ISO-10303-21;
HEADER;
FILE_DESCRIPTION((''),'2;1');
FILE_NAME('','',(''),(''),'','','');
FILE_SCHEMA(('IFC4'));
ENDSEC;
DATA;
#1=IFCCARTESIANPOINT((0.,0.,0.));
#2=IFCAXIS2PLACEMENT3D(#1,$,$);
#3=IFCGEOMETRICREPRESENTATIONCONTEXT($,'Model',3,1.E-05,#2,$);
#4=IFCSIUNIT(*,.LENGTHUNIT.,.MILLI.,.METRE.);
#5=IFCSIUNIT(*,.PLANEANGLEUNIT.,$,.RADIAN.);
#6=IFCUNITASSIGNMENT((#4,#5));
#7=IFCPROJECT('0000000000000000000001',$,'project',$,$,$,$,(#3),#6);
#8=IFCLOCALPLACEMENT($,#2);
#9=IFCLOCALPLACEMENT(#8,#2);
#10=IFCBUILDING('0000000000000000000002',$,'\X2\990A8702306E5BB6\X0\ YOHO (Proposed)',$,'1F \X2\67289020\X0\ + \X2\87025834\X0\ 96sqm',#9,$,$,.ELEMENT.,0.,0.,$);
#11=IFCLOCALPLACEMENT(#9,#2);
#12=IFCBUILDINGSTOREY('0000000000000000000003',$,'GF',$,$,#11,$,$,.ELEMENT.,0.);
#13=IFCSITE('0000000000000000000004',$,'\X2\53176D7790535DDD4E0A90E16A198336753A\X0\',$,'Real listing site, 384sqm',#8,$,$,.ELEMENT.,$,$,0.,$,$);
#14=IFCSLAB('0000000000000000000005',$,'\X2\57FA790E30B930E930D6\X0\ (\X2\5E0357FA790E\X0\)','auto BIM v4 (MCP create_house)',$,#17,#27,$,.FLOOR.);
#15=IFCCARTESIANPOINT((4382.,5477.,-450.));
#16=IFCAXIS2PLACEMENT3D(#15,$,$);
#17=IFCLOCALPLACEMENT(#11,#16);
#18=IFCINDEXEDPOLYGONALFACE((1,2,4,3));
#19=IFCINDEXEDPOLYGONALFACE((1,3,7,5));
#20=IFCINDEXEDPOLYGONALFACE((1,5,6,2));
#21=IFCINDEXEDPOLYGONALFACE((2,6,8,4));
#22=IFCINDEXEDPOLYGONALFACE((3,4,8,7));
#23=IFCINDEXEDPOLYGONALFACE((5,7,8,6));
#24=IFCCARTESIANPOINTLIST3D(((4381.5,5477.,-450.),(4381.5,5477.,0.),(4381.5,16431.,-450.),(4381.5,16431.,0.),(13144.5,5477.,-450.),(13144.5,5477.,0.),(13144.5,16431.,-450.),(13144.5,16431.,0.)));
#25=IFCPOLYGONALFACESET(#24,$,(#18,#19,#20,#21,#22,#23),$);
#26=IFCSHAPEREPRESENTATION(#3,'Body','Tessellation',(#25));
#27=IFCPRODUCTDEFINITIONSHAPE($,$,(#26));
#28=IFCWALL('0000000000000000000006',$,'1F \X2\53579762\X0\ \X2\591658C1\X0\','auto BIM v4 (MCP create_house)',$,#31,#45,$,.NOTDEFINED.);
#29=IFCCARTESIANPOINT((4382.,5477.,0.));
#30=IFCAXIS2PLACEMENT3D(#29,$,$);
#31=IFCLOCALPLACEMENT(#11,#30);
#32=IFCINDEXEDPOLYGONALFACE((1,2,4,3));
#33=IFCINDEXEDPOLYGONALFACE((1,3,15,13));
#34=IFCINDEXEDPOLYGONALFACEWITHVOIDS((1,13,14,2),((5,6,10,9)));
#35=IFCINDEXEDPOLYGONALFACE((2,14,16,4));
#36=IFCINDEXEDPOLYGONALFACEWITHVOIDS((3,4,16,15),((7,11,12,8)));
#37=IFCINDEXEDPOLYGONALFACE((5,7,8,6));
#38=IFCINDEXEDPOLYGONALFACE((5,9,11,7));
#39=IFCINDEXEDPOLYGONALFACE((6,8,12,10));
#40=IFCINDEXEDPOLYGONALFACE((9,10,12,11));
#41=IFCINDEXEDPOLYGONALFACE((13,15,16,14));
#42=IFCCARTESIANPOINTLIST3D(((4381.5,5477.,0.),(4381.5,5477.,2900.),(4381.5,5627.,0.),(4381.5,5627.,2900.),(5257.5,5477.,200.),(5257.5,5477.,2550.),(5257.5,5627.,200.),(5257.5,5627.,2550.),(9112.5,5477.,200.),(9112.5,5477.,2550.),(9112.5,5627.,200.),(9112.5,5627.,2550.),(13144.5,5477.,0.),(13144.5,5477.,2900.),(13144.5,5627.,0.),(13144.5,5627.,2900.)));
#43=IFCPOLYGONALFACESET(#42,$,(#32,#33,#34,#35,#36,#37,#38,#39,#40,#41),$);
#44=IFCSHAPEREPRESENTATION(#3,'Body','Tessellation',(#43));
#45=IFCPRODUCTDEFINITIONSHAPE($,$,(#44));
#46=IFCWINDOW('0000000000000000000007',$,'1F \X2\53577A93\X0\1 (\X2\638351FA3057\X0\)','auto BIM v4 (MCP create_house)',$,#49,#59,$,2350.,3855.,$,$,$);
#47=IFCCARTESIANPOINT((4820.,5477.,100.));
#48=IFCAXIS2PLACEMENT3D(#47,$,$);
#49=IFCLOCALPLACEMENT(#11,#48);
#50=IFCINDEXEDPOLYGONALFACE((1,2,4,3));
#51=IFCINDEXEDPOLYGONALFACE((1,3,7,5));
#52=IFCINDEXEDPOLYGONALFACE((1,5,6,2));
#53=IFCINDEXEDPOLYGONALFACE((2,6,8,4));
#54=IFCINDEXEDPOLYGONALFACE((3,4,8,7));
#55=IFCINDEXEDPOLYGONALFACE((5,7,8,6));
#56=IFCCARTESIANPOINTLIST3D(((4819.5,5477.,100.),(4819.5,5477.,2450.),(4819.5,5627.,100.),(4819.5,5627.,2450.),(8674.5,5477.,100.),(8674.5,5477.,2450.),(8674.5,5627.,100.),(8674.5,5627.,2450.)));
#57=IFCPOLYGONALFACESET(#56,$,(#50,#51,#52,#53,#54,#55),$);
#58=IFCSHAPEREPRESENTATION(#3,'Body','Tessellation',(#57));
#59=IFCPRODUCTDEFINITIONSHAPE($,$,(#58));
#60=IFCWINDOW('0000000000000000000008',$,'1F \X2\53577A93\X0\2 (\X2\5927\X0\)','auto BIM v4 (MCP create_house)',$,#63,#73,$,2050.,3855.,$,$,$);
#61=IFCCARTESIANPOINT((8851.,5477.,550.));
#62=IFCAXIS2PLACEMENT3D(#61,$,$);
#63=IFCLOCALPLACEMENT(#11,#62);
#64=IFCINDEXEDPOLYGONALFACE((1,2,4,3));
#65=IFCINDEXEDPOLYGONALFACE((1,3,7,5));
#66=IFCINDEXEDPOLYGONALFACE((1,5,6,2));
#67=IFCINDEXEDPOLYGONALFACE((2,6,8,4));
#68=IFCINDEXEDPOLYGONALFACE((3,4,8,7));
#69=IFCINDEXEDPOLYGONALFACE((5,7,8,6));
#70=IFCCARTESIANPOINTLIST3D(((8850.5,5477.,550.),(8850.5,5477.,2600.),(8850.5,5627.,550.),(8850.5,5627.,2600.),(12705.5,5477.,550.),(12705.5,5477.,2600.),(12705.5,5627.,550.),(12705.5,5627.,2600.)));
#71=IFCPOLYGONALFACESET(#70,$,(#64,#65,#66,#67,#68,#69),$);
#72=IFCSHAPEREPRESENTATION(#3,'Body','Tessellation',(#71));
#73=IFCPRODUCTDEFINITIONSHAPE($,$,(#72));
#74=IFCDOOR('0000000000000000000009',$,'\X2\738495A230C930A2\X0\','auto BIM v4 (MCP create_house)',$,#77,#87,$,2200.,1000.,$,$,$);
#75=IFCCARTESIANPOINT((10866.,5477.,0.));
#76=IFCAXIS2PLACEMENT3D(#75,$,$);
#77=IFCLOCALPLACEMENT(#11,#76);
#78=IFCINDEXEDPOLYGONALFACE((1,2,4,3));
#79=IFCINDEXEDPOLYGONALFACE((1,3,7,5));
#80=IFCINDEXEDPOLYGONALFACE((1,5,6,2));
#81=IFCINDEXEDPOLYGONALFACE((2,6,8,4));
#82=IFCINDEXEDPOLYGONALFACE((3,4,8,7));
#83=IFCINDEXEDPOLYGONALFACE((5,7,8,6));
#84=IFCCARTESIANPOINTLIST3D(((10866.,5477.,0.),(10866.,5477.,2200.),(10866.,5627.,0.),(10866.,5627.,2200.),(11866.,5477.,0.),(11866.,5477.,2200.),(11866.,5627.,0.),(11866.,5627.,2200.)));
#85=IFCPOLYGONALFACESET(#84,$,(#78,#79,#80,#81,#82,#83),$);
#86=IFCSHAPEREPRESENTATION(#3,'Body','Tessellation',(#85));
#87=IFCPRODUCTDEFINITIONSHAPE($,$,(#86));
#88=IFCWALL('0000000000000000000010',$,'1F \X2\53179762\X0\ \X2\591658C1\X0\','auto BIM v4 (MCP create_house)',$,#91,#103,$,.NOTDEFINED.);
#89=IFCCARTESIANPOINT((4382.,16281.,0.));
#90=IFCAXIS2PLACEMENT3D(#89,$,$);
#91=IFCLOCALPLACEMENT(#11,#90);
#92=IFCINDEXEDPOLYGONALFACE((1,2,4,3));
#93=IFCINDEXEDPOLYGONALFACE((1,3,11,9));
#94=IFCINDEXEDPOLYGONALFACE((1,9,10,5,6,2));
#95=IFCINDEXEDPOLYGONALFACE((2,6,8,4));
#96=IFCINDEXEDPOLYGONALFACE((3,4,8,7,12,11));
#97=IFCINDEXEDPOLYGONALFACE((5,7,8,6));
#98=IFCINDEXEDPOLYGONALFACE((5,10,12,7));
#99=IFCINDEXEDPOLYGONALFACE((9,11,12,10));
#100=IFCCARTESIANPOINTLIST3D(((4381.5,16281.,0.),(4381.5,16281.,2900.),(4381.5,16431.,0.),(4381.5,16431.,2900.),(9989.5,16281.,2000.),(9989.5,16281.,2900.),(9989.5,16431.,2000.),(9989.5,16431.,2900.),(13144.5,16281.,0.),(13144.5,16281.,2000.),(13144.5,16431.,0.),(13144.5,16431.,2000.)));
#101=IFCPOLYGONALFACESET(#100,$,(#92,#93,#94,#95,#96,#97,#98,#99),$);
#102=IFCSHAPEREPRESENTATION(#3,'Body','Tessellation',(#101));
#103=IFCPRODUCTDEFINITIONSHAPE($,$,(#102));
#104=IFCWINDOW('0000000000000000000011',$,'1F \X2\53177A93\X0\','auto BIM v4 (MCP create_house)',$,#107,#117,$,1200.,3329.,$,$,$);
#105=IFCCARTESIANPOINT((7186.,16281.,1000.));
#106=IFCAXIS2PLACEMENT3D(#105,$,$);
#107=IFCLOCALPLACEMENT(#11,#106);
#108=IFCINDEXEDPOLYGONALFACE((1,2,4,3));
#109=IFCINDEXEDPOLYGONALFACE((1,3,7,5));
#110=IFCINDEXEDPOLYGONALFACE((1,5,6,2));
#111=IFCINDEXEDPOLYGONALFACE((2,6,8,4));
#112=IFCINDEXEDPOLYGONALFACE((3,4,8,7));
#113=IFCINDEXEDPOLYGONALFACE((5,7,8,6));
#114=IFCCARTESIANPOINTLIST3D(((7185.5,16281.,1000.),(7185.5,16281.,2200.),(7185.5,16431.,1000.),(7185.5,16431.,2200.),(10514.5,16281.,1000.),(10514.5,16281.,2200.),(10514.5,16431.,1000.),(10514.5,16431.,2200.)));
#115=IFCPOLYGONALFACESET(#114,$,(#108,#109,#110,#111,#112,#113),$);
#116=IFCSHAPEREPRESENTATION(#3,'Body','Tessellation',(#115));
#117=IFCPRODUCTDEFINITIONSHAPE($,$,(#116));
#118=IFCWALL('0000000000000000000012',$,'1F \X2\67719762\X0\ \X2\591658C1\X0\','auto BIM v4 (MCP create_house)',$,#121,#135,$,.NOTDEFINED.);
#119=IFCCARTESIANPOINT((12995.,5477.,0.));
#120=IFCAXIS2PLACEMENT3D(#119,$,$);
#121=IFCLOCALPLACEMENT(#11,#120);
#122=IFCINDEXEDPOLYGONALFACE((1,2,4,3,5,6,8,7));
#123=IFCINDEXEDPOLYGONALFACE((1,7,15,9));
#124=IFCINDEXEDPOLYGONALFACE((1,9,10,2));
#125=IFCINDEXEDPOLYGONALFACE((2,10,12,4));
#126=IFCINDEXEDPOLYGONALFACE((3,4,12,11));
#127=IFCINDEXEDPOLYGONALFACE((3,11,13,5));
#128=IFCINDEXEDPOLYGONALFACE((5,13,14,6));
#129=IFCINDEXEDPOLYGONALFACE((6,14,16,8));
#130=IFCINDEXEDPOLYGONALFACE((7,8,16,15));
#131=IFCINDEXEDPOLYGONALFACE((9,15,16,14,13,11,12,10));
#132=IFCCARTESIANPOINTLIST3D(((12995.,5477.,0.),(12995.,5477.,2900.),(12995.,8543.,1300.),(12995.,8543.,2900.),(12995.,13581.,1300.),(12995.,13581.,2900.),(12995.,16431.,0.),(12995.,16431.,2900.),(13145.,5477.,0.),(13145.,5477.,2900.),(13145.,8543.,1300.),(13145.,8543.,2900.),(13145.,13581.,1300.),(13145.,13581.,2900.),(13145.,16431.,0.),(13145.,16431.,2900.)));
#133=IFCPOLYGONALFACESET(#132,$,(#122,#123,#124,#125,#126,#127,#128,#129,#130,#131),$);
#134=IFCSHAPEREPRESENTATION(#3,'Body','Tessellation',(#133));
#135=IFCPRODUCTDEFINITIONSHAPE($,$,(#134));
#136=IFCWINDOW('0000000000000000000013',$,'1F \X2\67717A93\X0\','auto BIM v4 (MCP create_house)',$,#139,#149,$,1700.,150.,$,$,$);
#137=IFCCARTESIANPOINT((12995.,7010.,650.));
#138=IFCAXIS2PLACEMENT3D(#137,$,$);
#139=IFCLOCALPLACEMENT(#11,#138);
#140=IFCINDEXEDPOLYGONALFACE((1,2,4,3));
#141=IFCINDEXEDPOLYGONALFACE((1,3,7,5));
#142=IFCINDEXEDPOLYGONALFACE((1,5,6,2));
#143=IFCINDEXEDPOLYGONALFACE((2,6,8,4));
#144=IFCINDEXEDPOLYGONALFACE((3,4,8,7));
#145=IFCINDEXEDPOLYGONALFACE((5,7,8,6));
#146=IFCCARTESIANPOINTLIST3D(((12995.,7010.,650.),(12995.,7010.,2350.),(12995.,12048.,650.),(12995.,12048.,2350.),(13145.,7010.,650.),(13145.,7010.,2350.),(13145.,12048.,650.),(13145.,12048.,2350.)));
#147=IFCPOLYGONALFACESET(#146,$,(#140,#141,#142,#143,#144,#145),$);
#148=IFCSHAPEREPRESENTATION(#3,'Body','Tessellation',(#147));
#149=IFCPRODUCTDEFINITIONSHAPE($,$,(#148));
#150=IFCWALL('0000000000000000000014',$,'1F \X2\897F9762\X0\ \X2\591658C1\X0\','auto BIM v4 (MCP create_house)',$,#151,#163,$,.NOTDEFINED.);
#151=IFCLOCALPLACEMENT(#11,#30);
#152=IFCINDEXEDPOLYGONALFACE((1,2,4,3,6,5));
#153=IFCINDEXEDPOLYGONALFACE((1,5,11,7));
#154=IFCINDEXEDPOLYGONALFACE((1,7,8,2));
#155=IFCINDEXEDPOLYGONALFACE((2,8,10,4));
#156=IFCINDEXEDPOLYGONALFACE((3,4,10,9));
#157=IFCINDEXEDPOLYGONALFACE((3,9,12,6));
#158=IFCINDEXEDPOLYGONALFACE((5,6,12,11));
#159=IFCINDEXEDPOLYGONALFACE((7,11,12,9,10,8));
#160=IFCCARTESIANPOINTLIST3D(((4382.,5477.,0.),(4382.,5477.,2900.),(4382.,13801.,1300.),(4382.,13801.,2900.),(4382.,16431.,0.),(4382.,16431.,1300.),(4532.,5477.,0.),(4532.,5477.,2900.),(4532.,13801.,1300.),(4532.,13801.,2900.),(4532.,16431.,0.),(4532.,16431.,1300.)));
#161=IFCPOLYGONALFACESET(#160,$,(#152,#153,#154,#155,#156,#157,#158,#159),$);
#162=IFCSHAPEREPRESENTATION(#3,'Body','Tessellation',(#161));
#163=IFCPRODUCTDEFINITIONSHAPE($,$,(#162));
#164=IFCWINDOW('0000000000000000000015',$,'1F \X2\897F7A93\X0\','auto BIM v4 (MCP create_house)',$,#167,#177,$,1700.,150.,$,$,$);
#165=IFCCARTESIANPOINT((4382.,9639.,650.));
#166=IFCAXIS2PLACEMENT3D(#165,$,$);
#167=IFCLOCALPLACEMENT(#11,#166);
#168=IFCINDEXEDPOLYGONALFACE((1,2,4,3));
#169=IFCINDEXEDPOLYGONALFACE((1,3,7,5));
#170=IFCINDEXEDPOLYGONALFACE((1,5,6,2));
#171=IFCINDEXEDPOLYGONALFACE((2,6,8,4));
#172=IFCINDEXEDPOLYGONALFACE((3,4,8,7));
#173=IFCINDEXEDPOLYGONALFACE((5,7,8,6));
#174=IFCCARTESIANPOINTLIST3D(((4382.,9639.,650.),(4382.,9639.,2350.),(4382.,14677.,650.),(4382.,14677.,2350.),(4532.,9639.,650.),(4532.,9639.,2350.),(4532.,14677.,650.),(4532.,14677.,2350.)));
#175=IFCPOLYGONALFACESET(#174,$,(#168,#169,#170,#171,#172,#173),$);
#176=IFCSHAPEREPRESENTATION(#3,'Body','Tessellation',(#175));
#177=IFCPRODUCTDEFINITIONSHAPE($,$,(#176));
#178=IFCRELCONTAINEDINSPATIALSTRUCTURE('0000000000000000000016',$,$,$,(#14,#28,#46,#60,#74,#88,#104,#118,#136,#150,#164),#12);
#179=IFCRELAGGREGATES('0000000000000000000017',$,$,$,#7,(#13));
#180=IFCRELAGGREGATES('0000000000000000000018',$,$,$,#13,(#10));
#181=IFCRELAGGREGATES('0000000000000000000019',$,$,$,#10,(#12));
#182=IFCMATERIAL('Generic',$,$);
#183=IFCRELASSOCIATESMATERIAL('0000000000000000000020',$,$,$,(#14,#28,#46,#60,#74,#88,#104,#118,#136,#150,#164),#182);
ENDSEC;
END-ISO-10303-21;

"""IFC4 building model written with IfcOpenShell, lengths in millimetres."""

from ifc_helpers import new_model, si_unit, frame, frame_2d, origin, place, context, project, spatial, rectangle, extrude, material, element, fill, save


model = new_model("IFC4")

# Units and contexts
model_context = context("Model", 3, precision=1e-05, world=origin())
ifc_project = project(units=[si_unit("LENGTHUNIT", "METRE", prefix="MILLI"), si_unit("PLANEANGLEUNIT", "RADIAN")], contexts=[model_context])

# Site, building, storey
site_placement = place(None, origin())
site = spatial("IfcSite", under=ifc_project, at=site_placement, Name="北海道川上郡標茶町", ObjectType="Real listing site, 384sqm", CompositionType="ELEMENT", RefElevation=0.0)
building_placement = place(site_placement, origin())
building = spatial("IfcBuilding", under=site, at=building_placement, Name="養蜂の家 YOHO (Proposed)", ObjectType="1F 木造 + 蜂場 96sqm", CompositionType="ELEMENT", ElevationOfRefHeight=0.0, ElevationOfTerrain=0.0)
storey_placement = place(building_placement, origin())
storey = spatial("IfcBuildingStorey", under=building, at=storey_placement, Name="GF", CompositionType="ELEMENT", Elevation=0.0)

# Slab
ifc_material = material(Name="Generic")
slab_1_placement = place(storey_placement, frame((4382.0, 5477.0, -450.0)))
element("IfcSlab", 1, at=slab_1_placement, inside=storey, material=ifc_material, Name="基礎スラブ (布基礎)", Description="auto BIM v4 (MCP create_house)", PredefinedType="FLOOR", context=model_context, shape_type="SweptSolid", body=[
    extrude(rectangle(XDim=8763.0, YDim=10954.0, at=frame_2d((4381.0, 5477.0))), frame((4382.0, 5477.0, -450.0)), (0.0, 0.0, 1.0), 450.0),
])

# Wall, openings, windows, door
wall_1_placement = place(storey_placement, frame((4382.0, 5477.0, 0.0)))
wall_1 = element("IfcWall", 2, at=wall_1_placement, inside=storey, material=ifc_material, Name="1F 南面 外壁", Description="auto BIM v4 (MCP create_house)", PredefinedType="NOTDEFINED", context=model_context, shape_type="SweptSolid", body=[
    extrude(rectangle(XDim=8763.0, YDim=150.0, at=frame_2d((4381.0, 75.0))), frame((4382.0, 5477.0, 0.0)), (0.0, 0.0, 1.0), 2900.0),
])
opening_1_placement = place(storey_placement, frame((4820.0, 5477.0, 100.0)))
opening_1 = element("IfcOpeningElement", 3, at=opening_1_placement, cuts=wall_1, PredefinedType="NOTDEFINED", context=model_context, shape_type="SweptSolid", body=[
    extrude(rectangle(XDim=3855.0, YDim=150.0, at=frame_2d((1927.0, 75.0))), frame((4820.0, 5477.0, 100.0)), (0.0, 0.0, 1.0), 2350.0),
])
opening_2_placement = place(storey_placement, frame((8851.0, 5477.0, 550.0)))
opening_2 = element("IfcOpeningElement", 4, at=opening_2_placement, cuts=wall_1, PredefinedType="NOTDEFINED", context=model_context, shape_type="SweptSolid", body=[
    extrude(rectangle(XDim=3855.0, YDim=150.0, at=frame_2d((1927.0, 75.0))), frame((8851.0, 5477.0, 550.0)), (0.0, 0.0, 1.0), 2050.0),
])
opening_3_placement = place(storey_placement, frame((10866.0, 5477.0, 0.0)))
opening_3 = element("IfcOpeningElement", 5, at=opening_3_placement, cuts=wall_1, PredefinedType="NOTDEFINED", context=model_context, shape_type="SweptSolid", body=[
    extrude(rectangle(XDim=1000.0, YDim=150.0, at=frame_2d((500.0, 75.0))), frame((10866.0, 5477.0, 0.0)), (0.0, 0.0, 1.0), 2200.0),
])
window_1_placement = place(storey_placement, frame((4820.0, 5477.0, 100.0)))
window_1 = element("IfcWindow", 6, at=window_1_placement, inside=storey, material=ifc_material, Name="1F 南窓1 (掃出し)", Description="auto BIM v4 (MCP create_house)", OverallHeight=2350.0, OverallWidth=3855.0, context=model_context, shape_type="SweptSolid", body=[
    extrude(rectangle(XDim=3855.0, YDim=150.0, at=frame_2d((1927.0, 75.0))), frame((4820.0, 5477.0, 100.0)), (0.0, 0.0, 1.0), 2350.0),
])
fill(opening_1, window_1)
window_2_placement = place(storey_placement, frame((8851.0, 5477.0, 550.0)))
window_2 = element("IfcWindow", 7, at=window_2_placement, inside=storey, material=ifc_material, Name="1F 南窓2 (大)", Description="auto BIM v4 (MCP create_house)", OverallHeight=2050.0, OverallWidth=3855.0, context=model_context, shape_type="SweptSolid", body=[
    extrude(rectangle(XDim=3855.0, YDim=150.0, at=frame_2d((1927.0, 75.0))), frame((8851.0, 5477.0, 550.0)), (0.0, 0.0, 1.0), 2050.0),
])
fill(opening_2, window_2)
door_placement = place(storey_placement, frame((10866.0, 5477.0, 0.0)))
door = element("IfcDoor", 8, at=door_placement, inside=storey, material=ifc_material, Name="玄関ドア", Description="auto BIM v4 (MCP create_house)", OverallHeight=2200.0, OverallWidth=1000.0, context=model_context, shape_type="SweptSolid", body=[
    extrude(rectangle(XDim=1000.0, YDim=150.0, at=frame_2d((500.0, 75.0))), frame((10866.0, 5477.0, 0.0)), (0.0, 0.0, 1.0), 2200.0),
])
fill(opening_3, door)

# Walls, openings, windows
wall_2_placement = place(storey_placement, frame((4382.0, 16281.0, 0.0)))
wall_2 = element("IfcWall", 9, at=wall_2_placement, inside=storey, material=ifc_material, Name="1F 北面 外壁", Description="auto BIM v4 (MCP create_house)", PredefinedType="NOTDEFINED", context=model_context, shape_type="SweptSolid", body=[
    extrude(rectangle(XDim=8763.0, YDim=150.0, at=frame_2d((4381.0, 75.0))), frame((4382.0, 16281.0, 0.0)), (0.0, 0.0, 1.0), 2900.0),
])
opening_4_placement = place(storey_placement, frame((7186.0, 16281.0, 1000.0)))
opening_4 = element("IfcOpeningElement", 10, at=opening_4_placement, cuts=wall_2, PredefinedType="NOTDEFINED", context=model_context, shape_type="SweptSolid", body=[
    extrude(rectangle(XDim=3329.0, YDim=150.0, at=frame_2d((1664.0, 75.0))), frame((7186.0, 16281.0, 1000.0)), (0.0, 0.0, 1.0), 1200.0),
])
window_3_placement = place(storey_placement, frame((7186.0, 16281.0, 1000.0)))
window_3 = element("IfcWindow", 11, at=window_3_placement, inside=storey, material=ifc_material, Name="1F 北窓", Description="auto BIM v4 (MCP create_house)", OverallHeight=1200.0, OverallWidth=3329.0, context=model_context, shape_type="SweptSolid", body=[
    extrude(rectangle(XDim=3329.0, YDim=150.0, at=frame_2d((1664.0, 75.0))), frame((7186.0, 16281.0, 1000.0)), (0.0, 0.0, 1.0), 1200.0),
])
fill(opening_4, window_3)
wall_3_placement = place(storey_placement, frame((12995.0, 5477.0, 0.0)))
wall_3 = element("IfcWall", 12, at=wall_3_placement, inside=storey, material=ifc_material, Name="1F 東面 外壁", Description="auto BIM v4 (MCP create_house)", PredefinedType="NOTDEFINED", context=model_context, shape_type="SweptSolid", body=[
    extrude(rectangle(XDim=150.0, YDim=10954.0, at=frame_2d((75.0, 5477.0))), frame((12995.0, 5477.0, 0.0)), (0.0, 0.0, 1.0), 2900.0),
])
opening_5_placement = place(storey_placement, frame((12995.0, 7010.0, 650.0)))
opening_5 = element("IfcOpeningElement", 13, at=opening_5_placement, cuts=wall_3, PredefinedType="NOTDEFINED", context=model_context, shape_type="SweptSolid", body=[
    extrude(rectangle(XDim=150.0, YDim=5038.0, at=frame_2d((75.0, 2519.0))), frame((12995.0, 7010.0, 650.0)), (0.0, 0.0, 1.0), 1700.0),
])
window_4_placement = place(storey_placement, frame((12995.0, 7010.0, 650.0)))
window_4 = element("IfcWindow", 14, at=window_4_placement, inside=storey, material=ifc_material, Name="1F 東窓", Description="auto BIM v4 (MCP create_house)", OverallHeight=1700.0, OverallWidth=150.0, context=model_context, shape_type="SweptSolid", body=[
    extrude(rectangle(XDim=150.0, YDim=5038.0, at=frame_2d((75.0, 2519.0))), frame((12995.0, 7010.0, 650.0)), (0.0, 0.0, 1.0), 1700.0),
])
fill(opening_5, window_4)
wall_4_placement = place(storey_placement, frame((4382.0, 5477.0, 0.0)))
wall_4 = element("IfcWall", 15, at=wall_4_placement, inside=storey, material=ifc_material, Name="1F 西面 外壁", Description="auto BIM v4 (MCP create_house)", PredefinedType="NOTDEFINED", context=model_context, shape_type="SweptSolid", body=[
    extrude(rectangle(XDim=150.0, YDim=10954.0, at=frame_2d((75.0, 5477.0))), frame((4382.0, 5477.0, 0.0)), (0.0, 0.0, 1.0), 2900.0),
])
opening_6_placement = place(storey_placement, frame((4382.0, 9639.0, 650.0)))
opening_6 = element("IfcOpeningElement", 16, at=opening_6_placement, cuts=wall_4, PredefinedType="NOTDEFINED", context=model_context, shape_type="SweptSolid", body=[
    extrude(rectangle(XDim=150.0, YDim=5038.0, at=frame_2d((75.0, 2519.0))), frame((4382.0, 9639.0, 650.0)), (0.0, 0.0, 1.0), 1700.0),
])
window_5_placement = place(storey_placement, frame((4382.0, 9639.0, 650.0)))
window_5 = element("IfcWindow", 17, at=window_5_placement, inside=storey, material=ifc_material, Name="1F 西窓", Description="auto BIM v4 (MCP create_house)", OverallHeight=1700.0, OverallWidth=150.0, context=model_context, shape_type="SweptSolid", body=[
    extrude(rectangle(XDim=150.0, YDim=5038.0, at=frame_2d((75.0, 2519.0))), frame((4382.0, 9639.0, 650.0)), (0.0, 0.0, 1.0), 1700.0),
])
fill(opening_6, window_5)

save(model, "model.ifc")
